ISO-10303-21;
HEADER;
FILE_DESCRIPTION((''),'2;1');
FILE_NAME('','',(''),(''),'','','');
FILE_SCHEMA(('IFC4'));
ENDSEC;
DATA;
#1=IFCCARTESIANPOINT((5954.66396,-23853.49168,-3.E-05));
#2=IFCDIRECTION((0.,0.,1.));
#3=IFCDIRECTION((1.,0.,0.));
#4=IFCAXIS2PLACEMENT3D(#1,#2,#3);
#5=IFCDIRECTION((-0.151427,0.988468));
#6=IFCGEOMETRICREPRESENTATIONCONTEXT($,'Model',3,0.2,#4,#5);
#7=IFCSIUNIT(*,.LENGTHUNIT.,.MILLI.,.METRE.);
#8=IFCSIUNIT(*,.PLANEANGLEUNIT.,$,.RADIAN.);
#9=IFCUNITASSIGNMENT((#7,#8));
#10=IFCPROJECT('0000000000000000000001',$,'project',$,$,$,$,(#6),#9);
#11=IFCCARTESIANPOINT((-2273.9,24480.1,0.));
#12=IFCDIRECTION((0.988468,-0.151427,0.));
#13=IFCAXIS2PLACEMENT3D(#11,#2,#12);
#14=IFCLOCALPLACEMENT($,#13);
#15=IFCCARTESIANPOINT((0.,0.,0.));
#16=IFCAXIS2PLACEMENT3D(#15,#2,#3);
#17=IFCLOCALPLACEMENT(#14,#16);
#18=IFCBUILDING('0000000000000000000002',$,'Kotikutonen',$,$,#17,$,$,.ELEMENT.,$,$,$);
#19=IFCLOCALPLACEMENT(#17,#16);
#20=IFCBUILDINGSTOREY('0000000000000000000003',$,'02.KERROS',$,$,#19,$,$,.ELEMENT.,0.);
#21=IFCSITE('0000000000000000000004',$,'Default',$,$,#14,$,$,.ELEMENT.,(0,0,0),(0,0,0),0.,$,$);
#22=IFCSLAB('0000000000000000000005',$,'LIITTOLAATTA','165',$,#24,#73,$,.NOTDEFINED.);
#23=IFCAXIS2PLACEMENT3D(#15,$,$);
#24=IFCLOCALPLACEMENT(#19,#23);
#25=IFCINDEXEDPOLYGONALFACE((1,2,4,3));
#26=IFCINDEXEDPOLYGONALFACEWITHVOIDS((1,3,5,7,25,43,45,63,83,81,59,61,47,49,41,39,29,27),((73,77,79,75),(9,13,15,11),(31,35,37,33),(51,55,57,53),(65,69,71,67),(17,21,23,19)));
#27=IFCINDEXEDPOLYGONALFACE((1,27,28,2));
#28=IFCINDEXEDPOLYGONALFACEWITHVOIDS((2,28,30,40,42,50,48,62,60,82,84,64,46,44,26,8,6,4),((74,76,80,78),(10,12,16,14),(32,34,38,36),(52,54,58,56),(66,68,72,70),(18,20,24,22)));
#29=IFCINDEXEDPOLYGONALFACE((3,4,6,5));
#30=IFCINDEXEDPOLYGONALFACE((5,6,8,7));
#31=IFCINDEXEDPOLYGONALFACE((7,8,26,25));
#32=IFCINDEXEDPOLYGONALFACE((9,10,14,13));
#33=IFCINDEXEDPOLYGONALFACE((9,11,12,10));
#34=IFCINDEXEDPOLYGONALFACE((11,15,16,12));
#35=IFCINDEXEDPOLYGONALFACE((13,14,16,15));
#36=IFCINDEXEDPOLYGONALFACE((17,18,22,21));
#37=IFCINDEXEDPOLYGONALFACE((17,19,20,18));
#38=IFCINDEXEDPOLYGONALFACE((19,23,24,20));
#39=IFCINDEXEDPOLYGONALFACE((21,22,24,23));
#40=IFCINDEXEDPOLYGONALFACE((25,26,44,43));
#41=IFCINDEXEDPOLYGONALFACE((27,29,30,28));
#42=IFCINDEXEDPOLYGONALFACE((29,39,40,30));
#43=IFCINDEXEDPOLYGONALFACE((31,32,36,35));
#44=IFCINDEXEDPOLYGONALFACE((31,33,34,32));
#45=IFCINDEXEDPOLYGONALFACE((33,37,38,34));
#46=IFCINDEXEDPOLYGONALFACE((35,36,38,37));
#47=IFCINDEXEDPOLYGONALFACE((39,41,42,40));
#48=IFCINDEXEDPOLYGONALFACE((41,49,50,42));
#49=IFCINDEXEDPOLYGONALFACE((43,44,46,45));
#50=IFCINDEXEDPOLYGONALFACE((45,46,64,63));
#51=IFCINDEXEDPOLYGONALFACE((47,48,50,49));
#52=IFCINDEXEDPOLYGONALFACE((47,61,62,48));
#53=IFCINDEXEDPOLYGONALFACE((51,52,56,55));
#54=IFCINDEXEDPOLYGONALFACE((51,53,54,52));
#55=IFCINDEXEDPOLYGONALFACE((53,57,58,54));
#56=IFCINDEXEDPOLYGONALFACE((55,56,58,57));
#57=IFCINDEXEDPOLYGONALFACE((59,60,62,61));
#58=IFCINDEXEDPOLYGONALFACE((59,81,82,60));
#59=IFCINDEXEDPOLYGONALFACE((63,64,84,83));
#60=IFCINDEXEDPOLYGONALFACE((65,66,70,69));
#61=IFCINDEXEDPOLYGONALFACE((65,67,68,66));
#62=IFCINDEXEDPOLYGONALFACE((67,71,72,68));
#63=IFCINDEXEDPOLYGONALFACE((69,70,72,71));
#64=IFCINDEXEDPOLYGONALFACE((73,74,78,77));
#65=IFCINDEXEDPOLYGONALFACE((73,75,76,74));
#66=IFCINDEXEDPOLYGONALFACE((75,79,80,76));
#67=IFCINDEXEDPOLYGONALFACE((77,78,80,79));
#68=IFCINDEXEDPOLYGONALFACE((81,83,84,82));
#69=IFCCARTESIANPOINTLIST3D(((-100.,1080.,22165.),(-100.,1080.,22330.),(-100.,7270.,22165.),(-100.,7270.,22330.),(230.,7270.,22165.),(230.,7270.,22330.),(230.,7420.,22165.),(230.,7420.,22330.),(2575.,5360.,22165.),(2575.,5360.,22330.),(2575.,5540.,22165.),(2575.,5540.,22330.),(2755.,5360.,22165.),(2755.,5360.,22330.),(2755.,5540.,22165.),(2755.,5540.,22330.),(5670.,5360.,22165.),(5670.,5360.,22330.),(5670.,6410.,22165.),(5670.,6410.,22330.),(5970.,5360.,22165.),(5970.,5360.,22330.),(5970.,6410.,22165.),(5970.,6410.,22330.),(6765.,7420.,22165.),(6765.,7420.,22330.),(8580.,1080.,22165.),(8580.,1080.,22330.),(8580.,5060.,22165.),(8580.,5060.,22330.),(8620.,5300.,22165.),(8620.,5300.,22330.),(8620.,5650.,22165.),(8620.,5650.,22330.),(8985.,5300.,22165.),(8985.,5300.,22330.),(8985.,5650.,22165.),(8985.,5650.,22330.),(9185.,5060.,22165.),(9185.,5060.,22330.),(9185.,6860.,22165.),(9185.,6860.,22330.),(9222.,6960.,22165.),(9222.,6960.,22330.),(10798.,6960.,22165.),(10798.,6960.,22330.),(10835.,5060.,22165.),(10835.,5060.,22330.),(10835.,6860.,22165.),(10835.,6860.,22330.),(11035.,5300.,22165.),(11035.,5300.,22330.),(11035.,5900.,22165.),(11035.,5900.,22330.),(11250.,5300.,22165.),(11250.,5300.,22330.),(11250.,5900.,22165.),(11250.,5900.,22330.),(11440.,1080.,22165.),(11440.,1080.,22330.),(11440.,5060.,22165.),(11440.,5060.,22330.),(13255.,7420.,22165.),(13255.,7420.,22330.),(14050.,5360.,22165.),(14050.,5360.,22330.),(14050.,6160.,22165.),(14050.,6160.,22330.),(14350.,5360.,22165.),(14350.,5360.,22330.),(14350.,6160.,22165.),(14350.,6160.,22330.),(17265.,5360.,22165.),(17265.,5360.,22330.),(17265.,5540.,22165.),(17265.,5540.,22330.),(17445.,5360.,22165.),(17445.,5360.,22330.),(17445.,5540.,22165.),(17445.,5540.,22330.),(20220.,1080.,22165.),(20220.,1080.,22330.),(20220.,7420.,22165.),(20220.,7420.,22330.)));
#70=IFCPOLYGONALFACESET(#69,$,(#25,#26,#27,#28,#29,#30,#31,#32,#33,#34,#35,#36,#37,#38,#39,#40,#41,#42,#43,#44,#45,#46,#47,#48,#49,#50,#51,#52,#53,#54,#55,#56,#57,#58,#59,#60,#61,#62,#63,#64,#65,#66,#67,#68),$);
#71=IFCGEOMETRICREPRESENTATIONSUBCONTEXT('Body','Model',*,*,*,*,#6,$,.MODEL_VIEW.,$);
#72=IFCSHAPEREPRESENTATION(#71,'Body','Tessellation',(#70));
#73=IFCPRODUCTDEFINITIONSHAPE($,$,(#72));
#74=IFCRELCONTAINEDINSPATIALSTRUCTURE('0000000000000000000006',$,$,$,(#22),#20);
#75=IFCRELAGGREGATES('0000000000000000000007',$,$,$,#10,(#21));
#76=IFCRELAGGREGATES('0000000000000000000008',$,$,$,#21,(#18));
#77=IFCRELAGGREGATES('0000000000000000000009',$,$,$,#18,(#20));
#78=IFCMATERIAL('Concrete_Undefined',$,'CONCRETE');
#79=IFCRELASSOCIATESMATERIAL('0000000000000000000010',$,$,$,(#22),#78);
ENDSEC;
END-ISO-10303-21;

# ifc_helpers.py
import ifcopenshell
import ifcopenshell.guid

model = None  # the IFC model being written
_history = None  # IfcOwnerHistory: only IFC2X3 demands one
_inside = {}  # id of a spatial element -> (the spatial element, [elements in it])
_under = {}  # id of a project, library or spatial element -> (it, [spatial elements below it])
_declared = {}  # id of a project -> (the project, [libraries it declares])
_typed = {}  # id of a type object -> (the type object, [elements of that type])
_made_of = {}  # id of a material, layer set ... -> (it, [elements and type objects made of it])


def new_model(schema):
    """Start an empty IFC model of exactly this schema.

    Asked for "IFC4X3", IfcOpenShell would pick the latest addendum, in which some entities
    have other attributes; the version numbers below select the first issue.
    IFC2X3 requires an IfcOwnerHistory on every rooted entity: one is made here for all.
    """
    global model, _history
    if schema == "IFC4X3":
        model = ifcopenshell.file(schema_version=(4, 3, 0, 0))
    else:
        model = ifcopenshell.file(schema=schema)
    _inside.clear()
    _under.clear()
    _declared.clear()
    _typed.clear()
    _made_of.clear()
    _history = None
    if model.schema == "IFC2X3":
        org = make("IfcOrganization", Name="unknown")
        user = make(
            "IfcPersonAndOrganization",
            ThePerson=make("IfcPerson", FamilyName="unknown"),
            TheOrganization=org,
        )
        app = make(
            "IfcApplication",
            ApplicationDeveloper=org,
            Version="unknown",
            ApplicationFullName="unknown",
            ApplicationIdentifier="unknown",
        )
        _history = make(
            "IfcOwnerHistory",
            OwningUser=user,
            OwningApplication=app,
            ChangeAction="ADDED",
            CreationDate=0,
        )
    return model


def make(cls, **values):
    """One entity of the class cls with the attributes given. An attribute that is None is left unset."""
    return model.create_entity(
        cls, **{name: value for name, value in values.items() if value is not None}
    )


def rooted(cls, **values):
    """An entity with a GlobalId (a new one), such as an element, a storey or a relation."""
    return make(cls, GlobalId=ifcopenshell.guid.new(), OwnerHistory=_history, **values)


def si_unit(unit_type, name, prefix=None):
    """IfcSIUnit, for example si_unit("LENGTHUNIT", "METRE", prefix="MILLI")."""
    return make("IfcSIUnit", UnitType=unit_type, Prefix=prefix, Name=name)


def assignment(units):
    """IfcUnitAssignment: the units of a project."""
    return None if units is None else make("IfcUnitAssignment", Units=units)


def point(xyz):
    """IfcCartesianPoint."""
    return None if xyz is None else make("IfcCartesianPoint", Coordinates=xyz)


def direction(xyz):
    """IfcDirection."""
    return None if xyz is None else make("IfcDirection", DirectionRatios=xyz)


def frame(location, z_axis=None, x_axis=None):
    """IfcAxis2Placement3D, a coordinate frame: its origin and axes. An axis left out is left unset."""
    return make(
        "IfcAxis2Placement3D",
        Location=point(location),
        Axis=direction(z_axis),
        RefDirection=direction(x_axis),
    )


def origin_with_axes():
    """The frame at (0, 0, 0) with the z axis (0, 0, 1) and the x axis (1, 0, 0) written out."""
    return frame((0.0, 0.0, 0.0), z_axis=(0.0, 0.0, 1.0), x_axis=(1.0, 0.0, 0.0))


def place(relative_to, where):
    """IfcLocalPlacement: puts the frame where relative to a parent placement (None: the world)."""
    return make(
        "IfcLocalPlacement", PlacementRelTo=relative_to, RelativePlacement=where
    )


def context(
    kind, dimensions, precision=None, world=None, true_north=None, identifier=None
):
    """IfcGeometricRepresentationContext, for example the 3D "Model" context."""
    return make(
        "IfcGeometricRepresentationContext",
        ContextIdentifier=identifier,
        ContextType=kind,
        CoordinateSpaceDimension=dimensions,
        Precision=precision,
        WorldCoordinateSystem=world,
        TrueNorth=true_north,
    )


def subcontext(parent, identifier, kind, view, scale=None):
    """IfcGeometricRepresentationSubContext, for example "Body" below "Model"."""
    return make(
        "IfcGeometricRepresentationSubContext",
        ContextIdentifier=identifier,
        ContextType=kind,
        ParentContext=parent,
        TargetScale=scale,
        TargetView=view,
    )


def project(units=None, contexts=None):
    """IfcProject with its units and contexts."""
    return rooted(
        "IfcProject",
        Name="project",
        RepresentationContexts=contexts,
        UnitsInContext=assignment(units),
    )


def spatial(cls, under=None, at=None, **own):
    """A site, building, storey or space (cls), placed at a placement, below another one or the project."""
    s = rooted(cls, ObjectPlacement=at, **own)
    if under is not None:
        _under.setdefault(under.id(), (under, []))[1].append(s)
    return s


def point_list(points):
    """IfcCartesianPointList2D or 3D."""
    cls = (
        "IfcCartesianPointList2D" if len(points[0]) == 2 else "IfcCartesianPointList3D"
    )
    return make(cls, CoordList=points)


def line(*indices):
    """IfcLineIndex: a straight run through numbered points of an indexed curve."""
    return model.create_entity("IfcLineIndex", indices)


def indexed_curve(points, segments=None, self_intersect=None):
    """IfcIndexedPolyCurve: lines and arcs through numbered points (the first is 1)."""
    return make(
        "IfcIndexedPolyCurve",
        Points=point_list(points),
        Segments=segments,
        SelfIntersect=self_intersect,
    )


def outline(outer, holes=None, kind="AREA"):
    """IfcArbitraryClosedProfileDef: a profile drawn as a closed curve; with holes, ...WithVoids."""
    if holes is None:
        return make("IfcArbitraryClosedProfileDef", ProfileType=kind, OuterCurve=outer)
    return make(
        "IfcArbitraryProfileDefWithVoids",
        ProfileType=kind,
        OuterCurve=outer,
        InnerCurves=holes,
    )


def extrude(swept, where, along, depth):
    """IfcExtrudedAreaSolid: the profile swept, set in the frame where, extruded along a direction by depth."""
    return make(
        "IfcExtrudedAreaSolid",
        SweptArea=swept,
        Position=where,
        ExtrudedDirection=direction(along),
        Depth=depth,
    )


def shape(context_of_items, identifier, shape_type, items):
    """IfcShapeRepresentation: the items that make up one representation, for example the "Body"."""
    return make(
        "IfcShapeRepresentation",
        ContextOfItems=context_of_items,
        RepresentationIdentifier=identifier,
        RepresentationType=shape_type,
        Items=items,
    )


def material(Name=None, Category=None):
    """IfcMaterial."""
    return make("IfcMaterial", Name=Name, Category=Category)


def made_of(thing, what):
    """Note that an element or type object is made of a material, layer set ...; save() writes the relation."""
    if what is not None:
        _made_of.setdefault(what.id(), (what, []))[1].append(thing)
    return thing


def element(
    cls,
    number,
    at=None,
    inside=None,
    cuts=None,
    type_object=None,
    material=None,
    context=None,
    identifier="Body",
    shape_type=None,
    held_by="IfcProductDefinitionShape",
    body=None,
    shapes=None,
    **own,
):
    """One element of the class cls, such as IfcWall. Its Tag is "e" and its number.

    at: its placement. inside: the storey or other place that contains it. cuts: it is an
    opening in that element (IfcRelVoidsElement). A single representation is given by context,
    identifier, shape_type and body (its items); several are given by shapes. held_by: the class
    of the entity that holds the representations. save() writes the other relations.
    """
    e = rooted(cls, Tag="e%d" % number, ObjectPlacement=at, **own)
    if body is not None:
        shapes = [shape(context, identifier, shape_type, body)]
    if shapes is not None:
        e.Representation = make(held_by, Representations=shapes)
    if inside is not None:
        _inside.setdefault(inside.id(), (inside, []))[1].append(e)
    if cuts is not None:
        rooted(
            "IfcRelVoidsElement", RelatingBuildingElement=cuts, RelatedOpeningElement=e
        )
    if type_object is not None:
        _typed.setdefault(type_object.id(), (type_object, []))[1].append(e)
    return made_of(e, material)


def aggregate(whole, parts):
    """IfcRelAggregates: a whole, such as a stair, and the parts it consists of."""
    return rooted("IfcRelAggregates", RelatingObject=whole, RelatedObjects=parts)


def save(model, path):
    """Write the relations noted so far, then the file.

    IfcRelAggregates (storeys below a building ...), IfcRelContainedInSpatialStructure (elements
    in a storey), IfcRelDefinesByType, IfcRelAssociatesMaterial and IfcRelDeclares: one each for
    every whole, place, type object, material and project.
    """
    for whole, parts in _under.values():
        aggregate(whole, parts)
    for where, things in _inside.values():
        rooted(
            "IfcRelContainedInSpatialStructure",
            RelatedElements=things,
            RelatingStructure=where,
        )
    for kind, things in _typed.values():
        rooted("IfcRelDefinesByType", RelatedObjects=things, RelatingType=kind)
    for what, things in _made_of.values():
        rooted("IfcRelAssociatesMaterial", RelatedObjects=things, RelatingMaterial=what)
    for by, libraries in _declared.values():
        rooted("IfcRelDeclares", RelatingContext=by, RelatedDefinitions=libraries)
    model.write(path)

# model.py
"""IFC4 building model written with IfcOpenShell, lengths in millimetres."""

from ifc_helpers import new_model, si_unit, direction, frame, origin_with_axes, place, context, subcontext, project, spatial, line, indexed_curve, outline, extrude, material, element, save


model = new_model("IFC4")

# Units and contexts
model_context = context("Model", 3, precision=0.2, world=frame((5954.66396, -23853.49168, -3e-05), z_axis=(0.0, 0.0, 1.0), x_axis=(1.0, 0.0, 0.0)), true_north=direction((-0.151427, 0.988468)))
body_context = subcontext(model_context, "Body", "Model", "MODEL_VIEW")
ifc_project = project(units=[si_unit("LENGTHUNIT", "METRE", prefix="MILLI"), si_unit("PLANEANGLEUNIT", "RADIAN")], contexts=[model_context])

# Site, building, storey
site_placement = place(None, frame((-2273.9, 24480.1, 0.0), z_axis=(0.0, 0.0, 1.0), x_axis=(0.988468, -0.151427, 0.0)))
site = spatial("IfcSite", under=ifc_project, at=site_placement, Name="Default", CompositionType="ELEMENT", RefLatitude=(0, 0, 0), RefLongitude=(0, 0, 0), RefElevation=0.0)
building_placement = place(site_placement, origin_with_axes())
building = spatial("IfcBuilding", under=site, at=building_placement, Name="Kotikutonen", CompositionType="ELEMENT")
storey_placement = place(building_placement, origin_with_axes())
storey = spatial("IfcBuildingStorey", under=building, at=storey_placement, Name="02.KERROS", CompositionType="ELEMENT", Elevation=0.0)

# Shared definitions
ifc_material_1 = material(Name="Concrete_Undefined", Category="CONCRETE")

# Slab, voiding features
slab_1_placement = place(storey_placement, frame((-100.0, 7270.0, 22247.5), z_axis=(0.0, 0.0, 1.0), x_axis=(0.0, -1.0, 0.0)))
slab_1 = element("IfcSlab", 1, at=slab_1_placement, inside=storey, material=ifc_material_1, Name="LIITTOLAATTA", Description="165", PredefinedType="NOTDEFINED", context=body_context, shape_type="SolidModel", body=[
    extrude(outline(indexed_curve([(0.0, 0.0), (6190.0, 0.0), (6190.0, 8680.0), (7270.0, 8680.0), (7270.0, 11540.0), (6190.0, 11540.0), (6190.0, 20320.0), (-150.0, 20320.0), (-150.0, 13355.0), (310.0, 10898.0), (310.0, 9322.0), (-150.0, 6865.0), (-150.0, 330.0), (0.0, 330.0)], segments=[line(1, 2, 3, 4, 5, 6, 7, 8, 9, 10, 11, 12, 13, 14, 1)])), frame((0.0, 0.0, 82.5), z_axis=(0.0, 0.0, 1.0), x_axis=(1.0, 0.0, 0.0)), (0.0, 0.0, -1.0), 165.0),
])
voiding_feature_1_placement = place(slab_1_placement, frame((2210.0, 8680.0, 0.0), z_axis=(0.0, 0.0, 1.0), x_axis=(1.0, 0.0, 0.0)))
element("IfcVoidingFeature", 2, at=voiding_feature_1_placement, cuts=slab_1, Name="POLYGON CUT", PredefinedType="HOLE", context=body_context, shape_type="SolidModel", body=[
    extrude(outline(indexed_curve([(0.0, 0.0), (5060.0, 0.0), (5060.0, 2860.0), (0.0, 2860.0), (0.0, 2255.0), (-1800.0, 2255.0), (-1800.0, 605.0), (0.0, 605.0)], segments=[line(1, 2, 3, 4, 5, 6, 7, 8, 1)])), frame((0.0, 0.0, 157.5), z_axis=(0.0, 0.0, 1.0), x_axis=(1.0, 0.0, 0.0)), (0.0, 0.0, -1.0), 315.0),
])
voiding_feature_2_placement = place(slab_1_placement, frame((1620.0, 8720.0, 0.0), z_axis=(0.0, 0.0, 1.0), x_axis=(1.0, 0.0, 0.0)))
element("IfcVoidingFeature", 3, at=voiding_feature_2_placement, cuts=slab_1, Name="POLYGON CUT", PredefinedType="HOLE", context=body_context, shape_type="SolidModel", body=[
    extrude(outline(indexed_curve([(0.0, 0.0), (350.0, 0.0), (350.0, 365.0), (0.0, 365.0)], segments=[line(1, 2, 3, 4, 1)])), frame((0.0, 0.0, 157.5), z_axis=(0.0, 0.0, 1.0), x_axis=(1.0, 0.0, 0.0)), (0.0, 0.0, -1.0), 315.0),
])
voiding_feature_3_placement = place(slab_1_placement, frame((1370.0, 11135.0, 0.0), z_axis=(0.0, 0.0, 1.0), x_axis=(1.0, 0.0, 0.0)))
element("IfcVoidingFeature", 4, at=voiding_feature_3_placement, cuts=slab_1, Name="POLYGON CUT", PredefinedType="HOLE", context=body_context, shape_type="SolidModel", body=[
    extrude(outline(indexed_curve([(0.0, 0.0), (600.0, 0.0), (600.0, 215.0), (0.0, 215.0)], segments=[line(1, 2, 3, 4, 1)])), frame((0.0, 0.0, 157.5), z_axis=(0.0, 0.0, 1.0), x_axis=(1.0, 0.0, 0.0)), (0.0, 0.0, -1.0), 315.0),
])
voiding_feature_4_placement = place(slab_1_placement, frame((860.0, 5770.0, 0.0), z_axis=(0.0, 0.0, 1.0), x_axis=(1.0, 0.0, 0.0)))
element("IfcVoidingFeature", 5, at=voiding_feature_4_placement, cuts=slab_1, Name="POLYGON CUT", PredefinedType="HOLE", context=body_context, shape_type="SolidModel", body=[
    extrude(outline(indexed_curve([(0.0, 0.0), (1050.0, 0.0), (1050.0, 300.0), (0.0, 300.0)], segments=[line(1, 2, 3, 4, 1)])), frame((0.0, 0.0, 157.5), z_axis=(0.0, 0.0, 1.0), x_axis=(1.0, 0.0, 0.0)), (0.0, 0.0, -1.0), 315.0),
])
voiding_feature_5_placement = place(slab_1_placement, frame((1110.0, 14150.0, 0.0), z_axis=(0.0, 0.0, 1.0), x_axis=(1.0, 0.0, 0.0)))
element("IfcVoidingFeature", 6, at=voiding_feature_5_placement, cuts=slab_1, Name="POLYGON CUT", PredefinedType="HOLE", context=body_context, shape_type="SolidModel", body=[
    extrude(outline(indexed_curve([(0.0, 0.0), (800.0, 0.0), (800.0, 300.0), (0.0, 300.0)], segments=[line(1, 2, 3, 4, 1)])), frame((0.0, 0.0, 157.5), z_axis=(0.0, 0.0, 1.0), x_axis=(1.0, 0.0, 0.0)), (0.0, 0.0, -1.0), 315.0),
])
voiding_feature_6_placement = place(slab_1_placement, frame((1730.0, 2675.0, 0.0), z_axis=(0.0, 0.0, 1.0), x_axis=(1.0, 0.0, 0.0)))
element("IfcVoidingFeature", 7, at=voiding_feature_6_placement, cuts=slab_1, Name="POLYGON CUT", PredefinedType="HOLE", context=body_context, shape_type="SolidModel", body=[
    extrude(outline(indexed_curve([(0.0, 0.0), (180.0, 0.0), (180.0, 180.0), (0.0, 180.0)], segments=[line(1, 2, 3, 4, 1)])), frame((0.0, 0.0, 157.5), z_axis=(0.0, 0.0, 1.0), x_axis=(1.0, 0.0, 0.0)), (0.0, 0.0, -1.0), 315.0),
])
voiding_feature_7_placement = place(slab_1_placement, frame((1730.0, 17365.0, 0.0), z_axis=(0.0, 0.0, 1.0), x_axis=(1.0, 0.0, 0.0)))
element("IfcVoidingFeature", 8, at=voiding_feature_7_placement, cuts=slab_1, Name="POLYGON CUT", PredefinedType="HOLE", context=body_context, shape_type="SolidModel", body=[
    extrude(outline(indexed_curve([(0.0, 0.0), (180.0, 0.0), (180.0, 180.0), (0.0, 180.0)], segments=[line(1, 2, 3, 4, 1)])), frame((0.0, 0.0, 157.5), z_axis=(0.0, 0.0, 1.0), x_axis=(1.0, 0.0, 0.0)), (0.0, 0.0, -1.0), 315.0),
])

save(model, "model.ifc")
